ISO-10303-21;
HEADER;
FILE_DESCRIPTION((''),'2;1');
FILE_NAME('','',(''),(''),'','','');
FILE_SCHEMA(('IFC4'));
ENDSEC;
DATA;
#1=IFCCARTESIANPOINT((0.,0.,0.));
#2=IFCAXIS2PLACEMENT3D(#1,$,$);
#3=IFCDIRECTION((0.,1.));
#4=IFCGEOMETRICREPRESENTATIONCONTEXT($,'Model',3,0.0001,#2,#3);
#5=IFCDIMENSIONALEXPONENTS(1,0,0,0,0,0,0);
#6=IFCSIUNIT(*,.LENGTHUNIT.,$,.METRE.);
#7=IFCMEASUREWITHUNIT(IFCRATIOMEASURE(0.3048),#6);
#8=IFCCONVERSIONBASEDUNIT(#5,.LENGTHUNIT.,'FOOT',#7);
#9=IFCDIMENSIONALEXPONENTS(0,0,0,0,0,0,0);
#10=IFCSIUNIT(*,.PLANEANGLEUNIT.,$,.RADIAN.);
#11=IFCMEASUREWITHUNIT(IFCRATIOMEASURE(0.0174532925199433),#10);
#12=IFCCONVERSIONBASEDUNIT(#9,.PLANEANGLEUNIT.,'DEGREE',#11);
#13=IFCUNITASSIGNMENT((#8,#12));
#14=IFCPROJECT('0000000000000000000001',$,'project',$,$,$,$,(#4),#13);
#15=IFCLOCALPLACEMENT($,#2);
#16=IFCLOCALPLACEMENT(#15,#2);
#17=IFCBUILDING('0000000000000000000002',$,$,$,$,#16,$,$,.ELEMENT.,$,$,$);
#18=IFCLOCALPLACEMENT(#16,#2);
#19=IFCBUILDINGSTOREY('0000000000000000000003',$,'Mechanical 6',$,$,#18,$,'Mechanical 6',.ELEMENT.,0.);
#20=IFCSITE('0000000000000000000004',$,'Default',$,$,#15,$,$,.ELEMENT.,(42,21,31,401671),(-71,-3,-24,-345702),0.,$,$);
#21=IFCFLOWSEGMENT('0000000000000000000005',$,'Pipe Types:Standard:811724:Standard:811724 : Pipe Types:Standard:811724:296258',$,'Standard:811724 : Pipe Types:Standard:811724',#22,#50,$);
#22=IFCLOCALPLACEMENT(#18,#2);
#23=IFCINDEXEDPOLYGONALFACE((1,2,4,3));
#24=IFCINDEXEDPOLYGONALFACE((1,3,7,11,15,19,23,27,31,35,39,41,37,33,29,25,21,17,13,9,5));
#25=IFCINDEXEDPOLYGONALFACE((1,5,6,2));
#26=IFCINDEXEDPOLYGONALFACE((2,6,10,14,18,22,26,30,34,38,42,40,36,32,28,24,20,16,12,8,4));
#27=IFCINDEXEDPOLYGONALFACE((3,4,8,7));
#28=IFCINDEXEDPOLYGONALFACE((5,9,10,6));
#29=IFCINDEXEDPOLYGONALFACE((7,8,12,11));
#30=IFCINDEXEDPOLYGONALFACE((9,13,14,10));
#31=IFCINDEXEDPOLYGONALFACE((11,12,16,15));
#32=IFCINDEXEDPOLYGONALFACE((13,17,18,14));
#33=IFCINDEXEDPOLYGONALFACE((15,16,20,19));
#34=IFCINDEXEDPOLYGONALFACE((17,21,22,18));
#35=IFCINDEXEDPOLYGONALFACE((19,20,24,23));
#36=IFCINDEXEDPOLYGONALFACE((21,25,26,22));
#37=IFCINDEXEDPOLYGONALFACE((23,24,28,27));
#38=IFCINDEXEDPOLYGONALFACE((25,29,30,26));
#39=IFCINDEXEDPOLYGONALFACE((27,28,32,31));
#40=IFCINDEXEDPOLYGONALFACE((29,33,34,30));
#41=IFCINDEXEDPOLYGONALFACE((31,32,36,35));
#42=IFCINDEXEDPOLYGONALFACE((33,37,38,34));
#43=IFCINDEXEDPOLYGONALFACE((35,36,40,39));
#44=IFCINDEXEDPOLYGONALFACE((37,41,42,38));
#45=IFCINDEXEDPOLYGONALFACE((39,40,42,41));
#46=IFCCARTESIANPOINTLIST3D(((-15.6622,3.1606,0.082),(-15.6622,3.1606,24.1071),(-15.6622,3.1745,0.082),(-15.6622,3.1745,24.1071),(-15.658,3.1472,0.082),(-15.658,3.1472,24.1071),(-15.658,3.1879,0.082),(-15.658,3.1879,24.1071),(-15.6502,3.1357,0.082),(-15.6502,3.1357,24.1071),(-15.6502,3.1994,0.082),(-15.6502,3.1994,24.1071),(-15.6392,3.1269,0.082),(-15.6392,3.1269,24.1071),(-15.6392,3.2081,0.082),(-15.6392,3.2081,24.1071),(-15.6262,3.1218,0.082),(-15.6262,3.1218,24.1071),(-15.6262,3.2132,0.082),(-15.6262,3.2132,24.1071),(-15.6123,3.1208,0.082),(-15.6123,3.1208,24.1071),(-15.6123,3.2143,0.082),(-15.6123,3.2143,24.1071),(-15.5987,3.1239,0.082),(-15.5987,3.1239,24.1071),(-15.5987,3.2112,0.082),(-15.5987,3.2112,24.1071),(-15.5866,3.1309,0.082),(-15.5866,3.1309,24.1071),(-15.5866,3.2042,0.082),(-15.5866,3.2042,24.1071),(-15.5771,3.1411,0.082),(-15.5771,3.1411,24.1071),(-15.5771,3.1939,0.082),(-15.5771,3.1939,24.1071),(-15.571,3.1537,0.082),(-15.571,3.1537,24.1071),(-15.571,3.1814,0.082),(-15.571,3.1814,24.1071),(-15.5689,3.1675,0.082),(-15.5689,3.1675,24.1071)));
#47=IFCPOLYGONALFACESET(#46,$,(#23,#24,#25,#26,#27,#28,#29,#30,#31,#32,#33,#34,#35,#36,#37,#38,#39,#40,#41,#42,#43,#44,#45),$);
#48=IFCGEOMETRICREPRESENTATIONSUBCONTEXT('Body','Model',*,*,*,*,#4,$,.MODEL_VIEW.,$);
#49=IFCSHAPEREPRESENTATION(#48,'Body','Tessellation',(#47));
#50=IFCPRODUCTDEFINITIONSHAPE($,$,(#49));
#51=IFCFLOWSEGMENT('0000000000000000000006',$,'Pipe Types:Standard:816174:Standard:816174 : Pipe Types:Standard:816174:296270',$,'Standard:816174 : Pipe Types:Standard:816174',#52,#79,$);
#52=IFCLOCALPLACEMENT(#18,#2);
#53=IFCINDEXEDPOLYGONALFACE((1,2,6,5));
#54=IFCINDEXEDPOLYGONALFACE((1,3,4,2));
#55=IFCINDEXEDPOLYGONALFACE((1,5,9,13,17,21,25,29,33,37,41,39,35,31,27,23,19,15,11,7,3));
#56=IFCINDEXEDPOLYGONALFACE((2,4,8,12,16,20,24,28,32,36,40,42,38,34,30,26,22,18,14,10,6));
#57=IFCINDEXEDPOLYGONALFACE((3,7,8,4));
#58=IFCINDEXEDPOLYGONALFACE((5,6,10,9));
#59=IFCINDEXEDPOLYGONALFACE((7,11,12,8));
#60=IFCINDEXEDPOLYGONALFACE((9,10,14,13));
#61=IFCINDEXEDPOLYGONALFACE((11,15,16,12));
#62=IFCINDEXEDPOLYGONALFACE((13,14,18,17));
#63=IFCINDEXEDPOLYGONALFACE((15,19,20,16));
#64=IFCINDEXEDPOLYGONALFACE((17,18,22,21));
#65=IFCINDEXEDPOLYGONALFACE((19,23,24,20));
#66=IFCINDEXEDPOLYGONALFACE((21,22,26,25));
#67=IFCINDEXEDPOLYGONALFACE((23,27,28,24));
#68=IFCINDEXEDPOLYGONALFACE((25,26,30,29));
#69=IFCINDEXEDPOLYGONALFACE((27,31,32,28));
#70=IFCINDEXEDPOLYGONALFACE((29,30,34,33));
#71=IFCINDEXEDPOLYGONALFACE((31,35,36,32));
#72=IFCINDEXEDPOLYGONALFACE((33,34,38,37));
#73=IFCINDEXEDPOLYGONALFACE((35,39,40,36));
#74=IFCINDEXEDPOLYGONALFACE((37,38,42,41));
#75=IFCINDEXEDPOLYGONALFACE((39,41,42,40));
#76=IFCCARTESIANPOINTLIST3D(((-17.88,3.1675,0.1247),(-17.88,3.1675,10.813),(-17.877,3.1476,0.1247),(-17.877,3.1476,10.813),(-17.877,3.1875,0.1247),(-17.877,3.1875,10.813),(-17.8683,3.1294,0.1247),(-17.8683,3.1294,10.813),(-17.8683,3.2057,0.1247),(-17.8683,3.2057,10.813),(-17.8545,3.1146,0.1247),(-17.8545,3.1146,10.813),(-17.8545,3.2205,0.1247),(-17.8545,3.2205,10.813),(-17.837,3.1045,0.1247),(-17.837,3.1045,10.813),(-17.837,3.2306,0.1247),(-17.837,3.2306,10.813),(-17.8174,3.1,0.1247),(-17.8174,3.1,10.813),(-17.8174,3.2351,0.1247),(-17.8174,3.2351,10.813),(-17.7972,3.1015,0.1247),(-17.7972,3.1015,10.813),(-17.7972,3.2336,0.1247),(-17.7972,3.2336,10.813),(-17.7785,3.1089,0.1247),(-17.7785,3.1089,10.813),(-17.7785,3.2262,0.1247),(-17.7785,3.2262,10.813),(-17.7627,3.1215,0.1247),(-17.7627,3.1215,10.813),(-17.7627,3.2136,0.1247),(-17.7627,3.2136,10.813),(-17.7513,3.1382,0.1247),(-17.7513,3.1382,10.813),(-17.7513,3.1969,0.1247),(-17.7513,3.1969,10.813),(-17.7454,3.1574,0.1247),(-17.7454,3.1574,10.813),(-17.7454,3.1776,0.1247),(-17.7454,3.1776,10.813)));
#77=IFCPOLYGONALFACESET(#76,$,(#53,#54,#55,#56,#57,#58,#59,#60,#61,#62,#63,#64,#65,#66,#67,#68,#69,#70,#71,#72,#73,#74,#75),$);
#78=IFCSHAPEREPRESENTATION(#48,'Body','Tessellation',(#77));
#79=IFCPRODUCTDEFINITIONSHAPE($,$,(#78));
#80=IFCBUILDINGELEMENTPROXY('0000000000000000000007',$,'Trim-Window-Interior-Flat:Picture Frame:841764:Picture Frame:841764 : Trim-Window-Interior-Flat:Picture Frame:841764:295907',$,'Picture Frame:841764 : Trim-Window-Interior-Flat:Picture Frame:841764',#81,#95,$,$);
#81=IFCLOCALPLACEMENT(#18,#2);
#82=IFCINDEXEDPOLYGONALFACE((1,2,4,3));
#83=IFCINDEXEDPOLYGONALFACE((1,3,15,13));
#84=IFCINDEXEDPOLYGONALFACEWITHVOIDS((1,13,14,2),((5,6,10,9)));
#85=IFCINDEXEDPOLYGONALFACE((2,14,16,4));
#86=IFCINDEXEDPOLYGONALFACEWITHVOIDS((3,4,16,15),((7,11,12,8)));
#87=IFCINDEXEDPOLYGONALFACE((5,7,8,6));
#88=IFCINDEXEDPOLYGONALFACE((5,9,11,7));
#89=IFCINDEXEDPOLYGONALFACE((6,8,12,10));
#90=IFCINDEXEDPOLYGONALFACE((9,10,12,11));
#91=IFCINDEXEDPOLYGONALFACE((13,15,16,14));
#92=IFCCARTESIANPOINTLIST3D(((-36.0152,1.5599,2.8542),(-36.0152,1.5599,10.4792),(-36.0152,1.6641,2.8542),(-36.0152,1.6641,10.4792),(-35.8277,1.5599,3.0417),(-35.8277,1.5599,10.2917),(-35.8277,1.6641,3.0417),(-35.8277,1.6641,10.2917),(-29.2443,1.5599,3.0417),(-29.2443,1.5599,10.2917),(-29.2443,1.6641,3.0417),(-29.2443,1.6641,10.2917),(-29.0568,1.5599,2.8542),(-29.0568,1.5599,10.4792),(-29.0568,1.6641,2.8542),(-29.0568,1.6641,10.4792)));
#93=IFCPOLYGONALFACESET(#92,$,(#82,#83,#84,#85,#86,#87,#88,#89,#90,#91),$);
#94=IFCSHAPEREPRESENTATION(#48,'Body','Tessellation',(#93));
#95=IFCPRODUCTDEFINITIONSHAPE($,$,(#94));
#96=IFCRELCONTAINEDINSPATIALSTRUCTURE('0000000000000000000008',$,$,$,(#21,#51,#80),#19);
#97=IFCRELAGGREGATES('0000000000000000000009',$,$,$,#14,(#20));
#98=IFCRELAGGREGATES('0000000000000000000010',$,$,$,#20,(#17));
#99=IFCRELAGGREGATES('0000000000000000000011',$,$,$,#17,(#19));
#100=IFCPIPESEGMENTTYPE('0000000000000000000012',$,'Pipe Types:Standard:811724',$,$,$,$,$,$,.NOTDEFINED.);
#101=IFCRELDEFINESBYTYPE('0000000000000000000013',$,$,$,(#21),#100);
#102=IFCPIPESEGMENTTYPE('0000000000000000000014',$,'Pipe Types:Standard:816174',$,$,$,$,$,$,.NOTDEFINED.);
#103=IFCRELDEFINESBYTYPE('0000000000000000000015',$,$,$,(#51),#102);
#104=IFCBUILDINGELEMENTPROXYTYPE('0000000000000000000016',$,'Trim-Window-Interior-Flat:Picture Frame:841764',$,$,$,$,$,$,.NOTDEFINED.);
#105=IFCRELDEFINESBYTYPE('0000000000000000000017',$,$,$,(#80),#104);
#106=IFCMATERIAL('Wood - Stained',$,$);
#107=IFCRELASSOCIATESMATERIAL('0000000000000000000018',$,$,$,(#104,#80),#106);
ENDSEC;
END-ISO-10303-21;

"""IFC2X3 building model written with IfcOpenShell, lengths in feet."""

from ifc_helpers import new_model, entity, si_unit, converted_unit, direction, frame, origin, origin_2d_with_axis, place, context, subcontext, project, spatial, polyline, circle, outline, extrude, source, transform, mapped, material, type_object, type_shapes, element, save


model = new_model("IFC2X3")

# Units and contexts
model_context = context("Model", 3, precision=0.0001, world=origin(), true_north=direction((0.0, 1.0)))
body_context = subcontext(model_context, "Body", "Model", "MODEL_VIEW")
ifc_project = project(units=[converted_unit("LENGTHUNIT", "FOOT", entity("IfcRatioMeasure", 0.3048), si_unit("LENGTHUNIT", "METRE"), dimensions=[1, 0, 0, 0, 0, 0, 0]), converted_unit("PLANEANGLEUNIT", "DEGREE", entity("IfcRatioMeasure", 0.0174532925199433), si_unit("PLANEANGLEUNIT", "RADIAN"), dimensions=[0, 0, 0, 0, 0, 0, 0])], contexts=[model_context])

# Site, building, storey
site_placement = place(None, origin())
site = spatial("IfcSite", under=ifc_project, at=site_placement, Name="Default", CompositionType="ELEMENT", RefLatitude=(42, 21, 31, 401671), RefLongitude=(-71, -3, -24, -345702), RefElevation=0.0)
building_placement = place(site_placement, origin())
building = spatial("IfcBuilding", under=site, at=building_placement, CompositionType="ELEMENT")
storey_placement = place(building_placement, origin())
storey = spatial("IfcBuildingStorey", under=building, at=storey_placement, Name="Mechanical 6", LongName="Mechanical 6", CompositionType="ELEMENT", Elevation=0.0)

# Flow segments
pipe_segment_type_1 = type_object("IfcPipeSegmentType", Name="Pipe Types:Standard:811724", PredefinedType="NOTDEFINED")
shared_shape_1 = source(origin(), body_context, "Body", "SweptSolid", [
    extrude(circle(Radius=0.0469, at=origin_2d_with_axis()), frame((-15.6158, 3.1675, 0.082)), (0.0, 0.0, 1.0), 24.0251),
])
type_shapes(pipe_segment_type_1, [shared_shape_1])
flow_segment_1_placement = place(building_placement, origin())
element("IfcFlowSegment", 1, at=flow_segment_1_placement, inside=storey, type_object=pipe_segment_type_1, Name="Pipe Types:Standard:811724:Standard:811724 : Pipe Types:Standard:811724:296258", ObjectType="Standard:811724 : Pipe Types:Standard:811724", context=body_context, shape_type="MappedRepresentation", body=[
    mapped(shared_shape_1, transform((0.0, 0.0, 0.0), scale=1.0)),
])
pipe_segment_type_2 = type_object("IfcPipeSegmentType", Name="Pipe Types:Standard:816174", PredefinedType="NOTDEFINED")
shared_shape_2 = source(origin(), body_context, "Body", "SweptSolid", [
    extrude(circle(Radius=0.0677, at=origin_2d_with_axis()), frame((-17.8123, 3.1675, 0.1247), z_axis=(0.0, 0.0, 1.0), x_axis=(-1.0, 0.0, 0.0)), (0.0, 0.0, 1.0), 10.6883),
])
type_shapes(pipe_segment_type_2, [shared_shape_2])
flow_segment_2_placement = place(building_placement, origin())
element("IfcFlowSegment", 2, at=flow_segment_2_placement, inside=storey, type_object=pipe_segment_type_2, Name="Pipe Types:Standard:816174:Standard:816174 : Pipe Types:Standard:816174:296270", ObjectType="Standard:816174 : Pipe Types:Standard:816174", context=body_context, shape_type="MappedRepresentation", body=[
    mapped(shared_shape_2, transform((0.0, 0.0, 0.0), scale=1.0)),
])

# Building element proxy
ifc_material_1 = material(Name="Wood - Stained")
building_element_proxy_type = type_object("IfcBuildingElementProxyType", Name="Trim-Window-Interior-Flat:Picture Frame:841764", PredefinedType="NOTDEFINED", material=ifc_material_1)
shared_shape_3 = source(origin(), body_context, "Body", "SweptSolid", [
    extrude(outline(polyline([(-3.4792, -3.8125), (3.4792, -3.8125), (3.4792, 3.8125), (-3.4792, 3.8125), (-3.4792, -3.8125)]), holes=[polyline([(3.2917, 3.625), (3.2917, -3.625), (-3.2917, -3.625), (-3.2917, 3.625), (3.2917, 3.625)])]), frame((-32.536, 1.5599, 6.6667), z_axis=(0.0, 1.0, 0.0), x_axis=(1.0, 0.0, 0.0)), (0.0, 0.0, 1.0), 0.1042),
])
type_shapes(building_element_proxy_type, [shared_shape_3])
proxy_placement = place(building_placement, origin())
element("IfcBuildingElementProxy", 3, at=proxy_placement, inside=storey, type_object=building_element_proxy_type, material=ifc_material_1, Name="Trim-Window-Interior-Flat:Picture Frame:841764:Picture Frame:841764 : Trim-Window-Interior-Flat:Picture Frame:841764:295907", ObjectType="Picture Frame:841764 : Trim-Window-Interior-Flat:Picture Frame:841764", context=body_context, shape_type="MappedRepresentation", body=[
    mapped(shared_shape_3, transform((0.0, 0.0, 0.0), scale=1.0)),
])

save(model, "model.ifc")
